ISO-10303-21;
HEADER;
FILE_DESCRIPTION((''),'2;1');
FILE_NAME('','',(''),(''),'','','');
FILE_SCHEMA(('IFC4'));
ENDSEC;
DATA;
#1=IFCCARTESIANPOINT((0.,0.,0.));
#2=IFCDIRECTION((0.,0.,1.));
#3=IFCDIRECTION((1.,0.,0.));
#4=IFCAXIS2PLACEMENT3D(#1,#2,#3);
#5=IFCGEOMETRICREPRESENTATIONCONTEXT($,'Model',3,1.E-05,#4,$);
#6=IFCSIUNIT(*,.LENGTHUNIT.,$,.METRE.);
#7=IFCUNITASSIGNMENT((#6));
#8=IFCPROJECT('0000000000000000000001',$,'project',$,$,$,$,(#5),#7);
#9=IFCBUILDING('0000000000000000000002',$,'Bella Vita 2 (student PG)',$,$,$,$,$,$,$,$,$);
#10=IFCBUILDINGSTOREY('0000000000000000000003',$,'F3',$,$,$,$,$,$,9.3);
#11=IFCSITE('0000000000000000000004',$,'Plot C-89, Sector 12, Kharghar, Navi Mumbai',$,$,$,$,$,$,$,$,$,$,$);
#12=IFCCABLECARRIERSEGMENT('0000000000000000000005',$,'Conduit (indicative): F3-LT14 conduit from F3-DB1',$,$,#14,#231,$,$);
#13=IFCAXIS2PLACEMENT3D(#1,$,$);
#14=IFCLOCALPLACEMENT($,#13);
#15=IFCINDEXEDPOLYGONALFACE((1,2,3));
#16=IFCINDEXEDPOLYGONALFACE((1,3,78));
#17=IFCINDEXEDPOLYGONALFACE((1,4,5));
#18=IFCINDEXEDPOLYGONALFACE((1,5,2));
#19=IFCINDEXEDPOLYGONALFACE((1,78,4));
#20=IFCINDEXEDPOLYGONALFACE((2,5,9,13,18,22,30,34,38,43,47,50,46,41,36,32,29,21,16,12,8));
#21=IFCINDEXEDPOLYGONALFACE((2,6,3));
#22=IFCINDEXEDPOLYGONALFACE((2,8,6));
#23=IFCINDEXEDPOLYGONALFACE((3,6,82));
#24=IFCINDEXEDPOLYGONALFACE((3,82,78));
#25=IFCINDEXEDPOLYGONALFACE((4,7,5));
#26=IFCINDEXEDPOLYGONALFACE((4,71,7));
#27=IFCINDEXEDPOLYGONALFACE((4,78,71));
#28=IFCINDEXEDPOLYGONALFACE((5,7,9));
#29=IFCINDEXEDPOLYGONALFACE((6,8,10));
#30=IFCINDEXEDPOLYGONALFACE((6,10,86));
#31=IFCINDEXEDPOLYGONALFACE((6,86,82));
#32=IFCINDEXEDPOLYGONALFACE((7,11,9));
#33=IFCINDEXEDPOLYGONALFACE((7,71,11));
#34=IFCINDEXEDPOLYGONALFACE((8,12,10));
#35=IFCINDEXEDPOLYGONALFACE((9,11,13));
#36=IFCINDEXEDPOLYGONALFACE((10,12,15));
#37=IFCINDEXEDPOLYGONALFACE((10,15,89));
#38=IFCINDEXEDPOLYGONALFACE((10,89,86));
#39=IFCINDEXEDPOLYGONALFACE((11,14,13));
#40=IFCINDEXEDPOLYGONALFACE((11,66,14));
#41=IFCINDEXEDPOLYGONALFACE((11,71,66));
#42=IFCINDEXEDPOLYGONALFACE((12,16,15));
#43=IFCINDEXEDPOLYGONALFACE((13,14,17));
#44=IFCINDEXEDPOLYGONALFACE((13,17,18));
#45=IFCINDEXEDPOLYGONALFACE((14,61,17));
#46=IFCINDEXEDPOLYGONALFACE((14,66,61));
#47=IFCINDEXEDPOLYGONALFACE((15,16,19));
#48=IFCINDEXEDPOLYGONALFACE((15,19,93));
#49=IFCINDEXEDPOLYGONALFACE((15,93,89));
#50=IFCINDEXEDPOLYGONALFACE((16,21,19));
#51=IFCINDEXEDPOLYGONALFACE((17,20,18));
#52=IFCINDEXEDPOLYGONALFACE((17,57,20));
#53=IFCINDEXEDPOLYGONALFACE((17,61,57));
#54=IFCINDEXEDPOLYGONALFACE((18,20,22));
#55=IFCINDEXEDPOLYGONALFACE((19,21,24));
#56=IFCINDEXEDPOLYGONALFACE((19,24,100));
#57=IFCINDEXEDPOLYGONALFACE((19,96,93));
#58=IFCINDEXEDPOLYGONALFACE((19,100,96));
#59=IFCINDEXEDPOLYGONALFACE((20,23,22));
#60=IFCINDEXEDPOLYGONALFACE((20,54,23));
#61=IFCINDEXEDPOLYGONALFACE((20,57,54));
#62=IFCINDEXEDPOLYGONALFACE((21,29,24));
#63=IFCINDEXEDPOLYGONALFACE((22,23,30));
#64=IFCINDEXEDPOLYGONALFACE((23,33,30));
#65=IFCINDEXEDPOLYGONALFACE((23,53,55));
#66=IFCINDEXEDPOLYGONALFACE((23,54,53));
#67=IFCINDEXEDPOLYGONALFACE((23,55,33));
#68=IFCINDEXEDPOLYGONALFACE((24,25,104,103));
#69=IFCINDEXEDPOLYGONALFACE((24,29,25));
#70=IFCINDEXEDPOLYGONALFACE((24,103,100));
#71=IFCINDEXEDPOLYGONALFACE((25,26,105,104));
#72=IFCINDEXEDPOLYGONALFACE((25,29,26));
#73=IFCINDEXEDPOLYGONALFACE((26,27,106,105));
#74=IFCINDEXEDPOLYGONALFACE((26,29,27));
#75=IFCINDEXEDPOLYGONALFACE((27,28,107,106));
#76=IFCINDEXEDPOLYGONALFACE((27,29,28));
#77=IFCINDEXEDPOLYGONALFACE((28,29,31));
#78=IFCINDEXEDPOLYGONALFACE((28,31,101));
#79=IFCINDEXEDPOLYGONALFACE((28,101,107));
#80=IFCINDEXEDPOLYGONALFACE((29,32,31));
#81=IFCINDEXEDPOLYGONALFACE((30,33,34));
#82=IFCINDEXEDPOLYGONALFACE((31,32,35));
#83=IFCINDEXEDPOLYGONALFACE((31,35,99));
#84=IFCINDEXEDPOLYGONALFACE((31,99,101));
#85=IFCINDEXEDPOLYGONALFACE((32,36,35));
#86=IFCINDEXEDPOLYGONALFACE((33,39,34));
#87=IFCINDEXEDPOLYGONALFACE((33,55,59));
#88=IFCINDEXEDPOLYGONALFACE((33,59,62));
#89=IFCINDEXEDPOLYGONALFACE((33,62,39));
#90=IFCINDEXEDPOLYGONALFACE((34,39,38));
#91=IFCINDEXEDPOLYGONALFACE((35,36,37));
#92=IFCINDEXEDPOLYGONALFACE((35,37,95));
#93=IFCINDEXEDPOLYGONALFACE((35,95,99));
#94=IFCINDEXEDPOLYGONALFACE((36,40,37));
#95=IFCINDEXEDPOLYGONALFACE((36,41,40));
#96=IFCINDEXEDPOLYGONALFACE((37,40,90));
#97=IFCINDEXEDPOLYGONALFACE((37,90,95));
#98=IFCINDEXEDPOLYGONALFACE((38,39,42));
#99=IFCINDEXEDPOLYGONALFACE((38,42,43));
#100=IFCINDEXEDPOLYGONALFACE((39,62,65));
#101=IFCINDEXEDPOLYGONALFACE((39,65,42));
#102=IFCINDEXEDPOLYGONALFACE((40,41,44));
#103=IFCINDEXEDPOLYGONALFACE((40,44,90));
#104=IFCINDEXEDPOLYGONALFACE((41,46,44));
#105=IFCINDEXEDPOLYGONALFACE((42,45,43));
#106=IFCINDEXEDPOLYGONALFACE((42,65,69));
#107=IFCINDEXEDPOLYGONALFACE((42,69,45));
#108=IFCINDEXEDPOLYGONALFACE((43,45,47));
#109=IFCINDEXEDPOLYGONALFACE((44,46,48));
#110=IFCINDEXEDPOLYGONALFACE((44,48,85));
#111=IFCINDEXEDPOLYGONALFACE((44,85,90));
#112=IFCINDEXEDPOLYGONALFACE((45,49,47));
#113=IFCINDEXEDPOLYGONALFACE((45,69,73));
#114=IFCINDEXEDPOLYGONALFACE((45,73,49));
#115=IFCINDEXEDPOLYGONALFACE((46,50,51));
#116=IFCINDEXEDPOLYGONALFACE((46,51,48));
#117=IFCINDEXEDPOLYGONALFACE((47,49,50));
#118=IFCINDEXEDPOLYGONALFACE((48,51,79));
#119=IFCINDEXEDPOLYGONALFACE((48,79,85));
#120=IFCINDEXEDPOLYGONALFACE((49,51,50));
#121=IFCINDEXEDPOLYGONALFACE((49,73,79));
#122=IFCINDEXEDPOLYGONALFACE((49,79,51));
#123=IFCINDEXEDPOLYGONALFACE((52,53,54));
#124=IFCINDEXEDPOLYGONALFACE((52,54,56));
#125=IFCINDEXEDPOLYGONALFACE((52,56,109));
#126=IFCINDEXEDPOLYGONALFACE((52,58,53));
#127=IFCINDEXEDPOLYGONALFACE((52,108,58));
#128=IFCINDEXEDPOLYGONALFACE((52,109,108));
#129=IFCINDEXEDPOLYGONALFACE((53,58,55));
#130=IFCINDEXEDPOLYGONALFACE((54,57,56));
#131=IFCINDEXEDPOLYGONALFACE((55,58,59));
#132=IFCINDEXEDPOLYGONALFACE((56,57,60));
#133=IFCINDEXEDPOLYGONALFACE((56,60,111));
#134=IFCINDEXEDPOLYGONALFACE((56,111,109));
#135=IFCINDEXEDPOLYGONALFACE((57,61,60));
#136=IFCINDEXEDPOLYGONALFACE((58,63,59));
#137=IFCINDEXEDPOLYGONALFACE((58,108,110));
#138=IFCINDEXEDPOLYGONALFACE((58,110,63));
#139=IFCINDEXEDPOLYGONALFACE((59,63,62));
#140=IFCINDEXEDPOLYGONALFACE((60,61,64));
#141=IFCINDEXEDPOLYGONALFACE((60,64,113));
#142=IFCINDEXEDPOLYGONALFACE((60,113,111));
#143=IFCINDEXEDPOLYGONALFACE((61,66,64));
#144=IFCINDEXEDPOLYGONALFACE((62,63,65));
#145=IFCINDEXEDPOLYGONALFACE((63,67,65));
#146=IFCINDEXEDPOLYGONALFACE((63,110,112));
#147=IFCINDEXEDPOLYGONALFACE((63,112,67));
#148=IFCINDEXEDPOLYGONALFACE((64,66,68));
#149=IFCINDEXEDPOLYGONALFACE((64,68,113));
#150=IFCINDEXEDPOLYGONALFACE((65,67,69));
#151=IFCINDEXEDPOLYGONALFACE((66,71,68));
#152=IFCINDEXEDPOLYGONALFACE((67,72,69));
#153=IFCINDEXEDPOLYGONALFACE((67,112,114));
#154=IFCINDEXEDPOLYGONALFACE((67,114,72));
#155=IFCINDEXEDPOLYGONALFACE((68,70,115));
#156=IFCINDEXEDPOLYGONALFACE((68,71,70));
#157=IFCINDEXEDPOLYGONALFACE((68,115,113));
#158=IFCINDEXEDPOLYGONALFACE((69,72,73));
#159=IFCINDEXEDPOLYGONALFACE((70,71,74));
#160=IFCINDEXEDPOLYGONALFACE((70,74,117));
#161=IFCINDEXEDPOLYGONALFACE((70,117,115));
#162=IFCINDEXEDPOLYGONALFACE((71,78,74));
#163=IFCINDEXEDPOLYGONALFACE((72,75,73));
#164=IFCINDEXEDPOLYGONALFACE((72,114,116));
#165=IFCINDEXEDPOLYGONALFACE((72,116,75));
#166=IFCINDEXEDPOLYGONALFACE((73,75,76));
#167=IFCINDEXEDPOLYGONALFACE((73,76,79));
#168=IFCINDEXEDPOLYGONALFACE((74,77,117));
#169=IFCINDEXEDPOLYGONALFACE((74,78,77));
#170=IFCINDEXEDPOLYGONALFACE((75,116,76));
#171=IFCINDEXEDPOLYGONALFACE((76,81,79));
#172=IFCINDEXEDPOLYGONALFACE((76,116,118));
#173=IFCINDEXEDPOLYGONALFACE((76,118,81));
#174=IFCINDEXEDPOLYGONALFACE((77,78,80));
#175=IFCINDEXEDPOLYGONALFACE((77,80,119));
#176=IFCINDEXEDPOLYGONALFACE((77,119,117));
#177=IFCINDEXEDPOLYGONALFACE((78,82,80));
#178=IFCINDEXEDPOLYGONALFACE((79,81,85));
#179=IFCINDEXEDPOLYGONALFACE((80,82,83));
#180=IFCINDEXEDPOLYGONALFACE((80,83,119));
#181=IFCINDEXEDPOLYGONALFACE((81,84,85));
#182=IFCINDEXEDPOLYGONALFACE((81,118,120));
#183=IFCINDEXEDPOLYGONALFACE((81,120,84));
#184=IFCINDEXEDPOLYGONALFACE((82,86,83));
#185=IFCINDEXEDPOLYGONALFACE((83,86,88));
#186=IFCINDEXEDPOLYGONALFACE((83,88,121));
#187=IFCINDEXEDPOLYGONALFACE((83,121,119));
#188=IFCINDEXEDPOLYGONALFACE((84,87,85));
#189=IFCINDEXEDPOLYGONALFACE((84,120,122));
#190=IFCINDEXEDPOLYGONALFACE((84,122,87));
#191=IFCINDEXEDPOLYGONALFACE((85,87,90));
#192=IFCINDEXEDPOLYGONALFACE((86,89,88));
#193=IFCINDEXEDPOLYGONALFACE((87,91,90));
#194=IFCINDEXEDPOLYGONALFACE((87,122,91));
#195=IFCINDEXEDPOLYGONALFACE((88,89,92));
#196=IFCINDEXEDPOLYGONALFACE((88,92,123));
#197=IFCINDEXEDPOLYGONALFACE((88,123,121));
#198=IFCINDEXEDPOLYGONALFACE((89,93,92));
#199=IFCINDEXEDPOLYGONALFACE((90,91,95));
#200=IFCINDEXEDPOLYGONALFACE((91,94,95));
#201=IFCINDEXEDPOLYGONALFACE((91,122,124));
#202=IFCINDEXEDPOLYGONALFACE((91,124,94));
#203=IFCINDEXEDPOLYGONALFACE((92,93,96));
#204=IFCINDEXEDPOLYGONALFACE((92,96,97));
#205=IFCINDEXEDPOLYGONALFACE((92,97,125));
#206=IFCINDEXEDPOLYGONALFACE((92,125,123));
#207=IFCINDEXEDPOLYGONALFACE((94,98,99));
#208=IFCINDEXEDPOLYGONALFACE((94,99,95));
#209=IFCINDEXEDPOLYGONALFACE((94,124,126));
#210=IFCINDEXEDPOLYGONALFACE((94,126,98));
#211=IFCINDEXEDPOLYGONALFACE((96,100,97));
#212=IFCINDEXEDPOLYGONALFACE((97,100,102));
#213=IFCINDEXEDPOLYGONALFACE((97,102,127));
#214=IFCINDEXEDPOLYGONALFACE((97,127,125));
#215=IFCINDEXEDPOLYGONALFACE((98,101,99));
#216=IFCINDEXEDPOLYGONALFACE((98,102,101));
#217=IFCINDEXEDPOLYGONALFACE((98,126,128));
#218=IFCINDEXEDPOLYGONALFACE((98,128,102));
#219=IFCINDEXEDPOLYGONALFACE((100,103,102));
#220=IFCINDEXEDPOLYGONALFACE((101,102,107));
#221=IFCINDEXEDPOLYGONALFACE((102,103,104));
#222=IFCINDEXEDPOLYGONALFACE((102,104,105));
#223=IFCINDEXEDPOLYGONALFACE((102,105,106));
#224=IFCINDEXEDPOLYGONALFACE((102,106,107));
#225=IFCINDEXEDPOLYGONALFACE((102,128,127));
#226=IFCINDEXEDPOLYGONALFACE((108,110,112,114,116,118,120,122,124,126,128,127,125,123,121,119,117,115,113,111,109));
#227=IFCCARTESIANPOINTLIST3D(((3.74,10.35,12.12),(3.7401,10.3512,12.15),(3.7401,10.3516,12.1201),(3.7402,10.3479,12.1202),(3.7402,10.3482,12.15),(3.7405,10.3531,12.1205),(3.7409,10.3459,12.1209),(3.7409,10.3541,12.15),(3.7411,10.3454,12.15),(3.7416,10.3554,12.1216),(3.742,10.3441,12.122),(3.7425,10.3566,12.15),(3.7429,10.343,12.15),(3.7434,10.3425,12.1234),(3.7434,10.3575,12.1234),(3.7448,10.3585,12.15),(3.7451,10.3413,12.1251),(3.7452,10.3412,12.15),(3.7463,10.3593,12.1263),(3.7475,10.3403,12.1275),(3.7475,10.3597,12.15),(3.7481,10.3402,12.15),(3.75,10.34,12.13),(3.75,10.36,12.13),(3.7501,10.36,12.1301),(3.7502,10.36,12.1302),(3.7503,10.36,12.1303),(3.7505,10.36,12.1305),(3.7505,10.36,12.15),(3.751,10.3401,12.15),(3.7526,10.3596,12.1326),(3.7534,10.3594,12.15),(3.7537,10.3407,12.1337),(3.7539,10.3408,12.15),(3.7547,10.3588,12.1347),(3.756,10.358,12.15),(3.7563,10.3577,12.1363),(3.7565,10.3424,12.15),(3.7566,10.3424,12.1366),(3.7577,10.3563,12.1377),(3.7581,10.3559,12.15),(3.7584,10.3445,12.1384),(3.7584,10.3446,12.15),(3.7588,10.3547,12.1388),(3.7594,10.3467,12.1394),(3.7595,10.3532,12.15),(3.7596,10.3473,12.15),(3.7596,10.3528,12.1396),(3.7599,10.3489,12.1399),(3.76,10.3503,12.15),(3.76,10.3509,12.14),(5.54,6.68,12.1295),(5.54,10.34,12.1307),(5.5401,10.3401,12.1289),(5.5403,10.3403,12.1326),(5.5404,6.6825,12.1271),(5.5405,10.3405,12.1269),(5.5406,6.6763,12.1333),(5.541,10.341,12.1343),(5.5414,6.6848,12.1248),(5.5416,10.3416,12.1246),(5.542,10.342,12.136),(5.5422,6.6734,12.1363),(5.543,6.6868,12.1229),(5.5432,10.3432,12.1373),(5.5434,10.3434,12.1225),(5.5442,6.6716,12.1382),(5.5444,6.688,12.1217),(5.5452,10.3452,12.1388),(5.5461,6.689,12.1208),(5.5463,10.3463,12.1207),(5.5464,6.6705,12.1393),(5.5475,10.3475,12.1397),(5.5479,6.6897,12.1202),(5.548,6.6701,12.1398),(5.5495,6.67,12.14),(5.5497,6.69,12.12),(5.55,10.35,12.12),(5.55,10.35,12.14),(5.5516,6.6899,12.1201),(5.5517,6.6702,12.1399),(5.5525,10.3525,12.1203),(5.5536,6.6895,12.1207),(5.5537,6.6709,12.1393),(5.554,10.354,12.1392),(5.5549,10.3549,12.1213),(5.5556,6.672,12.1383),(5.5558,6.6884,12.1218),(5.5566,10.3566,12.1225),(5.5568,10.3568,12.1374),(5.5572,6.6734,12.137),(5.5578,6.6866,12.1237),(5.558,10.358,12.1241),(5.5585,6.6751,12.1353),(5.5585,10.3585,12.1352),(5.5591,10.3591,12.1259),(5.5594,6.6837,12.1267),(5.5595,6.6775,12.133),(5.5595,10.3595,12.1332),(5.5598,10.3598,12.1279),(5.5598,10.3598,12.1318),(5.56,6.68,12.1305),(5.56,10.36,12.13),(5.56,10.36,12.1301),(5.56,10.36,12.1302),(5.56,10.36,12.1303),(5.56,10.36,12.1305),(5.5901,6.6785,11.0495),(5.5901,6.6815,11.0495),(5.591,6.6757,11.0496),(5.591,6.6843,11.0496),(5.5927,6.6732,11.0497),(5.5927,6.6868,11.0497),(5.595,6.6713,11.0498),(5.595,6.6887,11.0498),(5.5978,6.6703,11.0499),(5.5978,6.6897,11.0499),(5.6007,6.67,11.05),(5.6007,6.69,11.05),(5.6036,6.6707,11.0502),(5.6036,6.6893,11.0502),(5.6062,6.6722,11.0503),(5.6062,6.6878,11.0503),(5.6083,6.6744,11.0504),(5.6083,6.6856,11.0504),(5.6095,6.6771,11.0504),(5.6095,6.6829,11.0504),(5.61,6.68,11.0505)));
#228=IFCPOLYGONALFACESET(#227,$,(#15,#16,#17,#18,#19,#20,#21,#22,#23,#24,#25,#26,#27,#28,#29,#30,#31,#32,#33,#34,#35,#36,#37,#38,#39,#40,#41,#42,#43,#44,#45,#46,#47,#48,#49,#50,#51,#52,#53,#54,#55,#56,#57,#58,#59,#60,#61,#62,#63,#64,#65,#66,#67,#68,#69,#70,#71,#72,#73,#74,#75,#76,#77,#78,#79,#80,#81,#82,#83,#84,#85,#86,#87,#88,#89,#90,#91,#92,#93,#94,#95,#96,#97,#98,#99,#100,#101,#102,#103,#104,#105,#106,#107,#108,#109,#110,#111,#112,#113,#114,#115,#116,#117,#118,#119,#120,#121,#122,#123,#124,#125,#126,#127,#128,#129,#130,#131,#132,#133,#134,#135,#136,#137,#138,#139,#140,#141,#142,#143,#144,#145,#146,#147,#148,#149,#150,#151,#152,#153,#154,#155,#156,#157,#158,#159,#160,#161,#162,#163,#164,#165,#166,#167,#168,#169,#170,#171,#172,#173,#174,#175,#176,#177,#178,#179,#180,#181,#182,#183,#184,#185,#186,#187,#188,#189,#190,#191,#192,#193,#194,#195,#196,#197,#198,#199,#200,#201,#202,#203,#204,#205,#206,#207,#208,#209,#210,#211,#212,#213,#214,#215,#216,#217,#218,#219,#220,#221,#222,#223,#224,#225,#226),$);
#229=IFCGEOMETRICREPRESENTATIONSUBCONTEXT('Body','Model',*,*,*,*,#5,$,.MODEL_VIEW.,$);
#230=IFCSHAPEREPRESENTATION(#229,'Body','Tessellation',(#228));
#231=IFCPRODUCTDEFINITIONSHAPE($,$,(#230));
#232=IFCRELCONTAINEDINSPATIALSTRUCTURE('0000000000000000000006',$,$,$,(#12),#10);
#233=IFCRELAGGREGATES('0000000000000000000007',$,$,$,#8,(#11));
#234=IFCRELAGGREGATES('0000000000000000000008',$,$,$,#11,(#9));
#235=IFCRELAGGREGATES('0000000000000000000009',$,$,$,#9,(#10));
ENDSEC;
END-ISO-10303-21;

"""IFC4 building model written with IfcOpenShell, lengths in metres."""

from ifc_helpers import new_model, entity, si_unit, origin, origin_with_axes, place, context, subcontext, project, spatial, element, save


model = new_model("IFC4")

# Units and contexts
model_context = context("Model", 3, precision=1e-05, world=origin_with_axes())
body_context = subcontext(model_context, "Body", "Model", "MODEL_VIEW")
ifc_project = project(units=[si_unit("LENGTHUNIT", "METRE")], contexts=[model_context])

# Site, building, storey
site = spatial("IfcSite", under=ifc_project, Name="Plot C-89, Sector 12, Kharghar, Navi Mumbai")
building = spatial("IfcBuilding", under=site, Name="Bella Vita 2 (student PG)")
storey = spatial("IfcBuildingStorey", under=building, Name="F3", Elevation=9.3)

# Cable carrier segment
cable_carrier_segment_1_placement = place(None, origin())
element("IfcCableCarrierSegment", 1, at=cable_carrier_segment_1_placement, inside=storey, Name="Conduit (indicative): F3-LT14 conduit from F3-DB1", context=body_context, shape_type="AdvancedSweptSolid", body=[
    entity("IfcSweptDiskSolid", entity("IfcPolyline", [entity("IfcCartesianPoint", [5.6, 6.68, 11.05]), entity("IfcCartesianPoint", [5.55, 6.68, 12.13]), entity("IfcCartesianPoint", [5.55, 10.35, 12.13]), entity("IfcCartesianPoint", [3.75, 10.35, 12.13]), entity("IfcCartesianPoint", [3.75, 10.35, 12.15])]), 0.01),
])

save(model, "model.ifc")
